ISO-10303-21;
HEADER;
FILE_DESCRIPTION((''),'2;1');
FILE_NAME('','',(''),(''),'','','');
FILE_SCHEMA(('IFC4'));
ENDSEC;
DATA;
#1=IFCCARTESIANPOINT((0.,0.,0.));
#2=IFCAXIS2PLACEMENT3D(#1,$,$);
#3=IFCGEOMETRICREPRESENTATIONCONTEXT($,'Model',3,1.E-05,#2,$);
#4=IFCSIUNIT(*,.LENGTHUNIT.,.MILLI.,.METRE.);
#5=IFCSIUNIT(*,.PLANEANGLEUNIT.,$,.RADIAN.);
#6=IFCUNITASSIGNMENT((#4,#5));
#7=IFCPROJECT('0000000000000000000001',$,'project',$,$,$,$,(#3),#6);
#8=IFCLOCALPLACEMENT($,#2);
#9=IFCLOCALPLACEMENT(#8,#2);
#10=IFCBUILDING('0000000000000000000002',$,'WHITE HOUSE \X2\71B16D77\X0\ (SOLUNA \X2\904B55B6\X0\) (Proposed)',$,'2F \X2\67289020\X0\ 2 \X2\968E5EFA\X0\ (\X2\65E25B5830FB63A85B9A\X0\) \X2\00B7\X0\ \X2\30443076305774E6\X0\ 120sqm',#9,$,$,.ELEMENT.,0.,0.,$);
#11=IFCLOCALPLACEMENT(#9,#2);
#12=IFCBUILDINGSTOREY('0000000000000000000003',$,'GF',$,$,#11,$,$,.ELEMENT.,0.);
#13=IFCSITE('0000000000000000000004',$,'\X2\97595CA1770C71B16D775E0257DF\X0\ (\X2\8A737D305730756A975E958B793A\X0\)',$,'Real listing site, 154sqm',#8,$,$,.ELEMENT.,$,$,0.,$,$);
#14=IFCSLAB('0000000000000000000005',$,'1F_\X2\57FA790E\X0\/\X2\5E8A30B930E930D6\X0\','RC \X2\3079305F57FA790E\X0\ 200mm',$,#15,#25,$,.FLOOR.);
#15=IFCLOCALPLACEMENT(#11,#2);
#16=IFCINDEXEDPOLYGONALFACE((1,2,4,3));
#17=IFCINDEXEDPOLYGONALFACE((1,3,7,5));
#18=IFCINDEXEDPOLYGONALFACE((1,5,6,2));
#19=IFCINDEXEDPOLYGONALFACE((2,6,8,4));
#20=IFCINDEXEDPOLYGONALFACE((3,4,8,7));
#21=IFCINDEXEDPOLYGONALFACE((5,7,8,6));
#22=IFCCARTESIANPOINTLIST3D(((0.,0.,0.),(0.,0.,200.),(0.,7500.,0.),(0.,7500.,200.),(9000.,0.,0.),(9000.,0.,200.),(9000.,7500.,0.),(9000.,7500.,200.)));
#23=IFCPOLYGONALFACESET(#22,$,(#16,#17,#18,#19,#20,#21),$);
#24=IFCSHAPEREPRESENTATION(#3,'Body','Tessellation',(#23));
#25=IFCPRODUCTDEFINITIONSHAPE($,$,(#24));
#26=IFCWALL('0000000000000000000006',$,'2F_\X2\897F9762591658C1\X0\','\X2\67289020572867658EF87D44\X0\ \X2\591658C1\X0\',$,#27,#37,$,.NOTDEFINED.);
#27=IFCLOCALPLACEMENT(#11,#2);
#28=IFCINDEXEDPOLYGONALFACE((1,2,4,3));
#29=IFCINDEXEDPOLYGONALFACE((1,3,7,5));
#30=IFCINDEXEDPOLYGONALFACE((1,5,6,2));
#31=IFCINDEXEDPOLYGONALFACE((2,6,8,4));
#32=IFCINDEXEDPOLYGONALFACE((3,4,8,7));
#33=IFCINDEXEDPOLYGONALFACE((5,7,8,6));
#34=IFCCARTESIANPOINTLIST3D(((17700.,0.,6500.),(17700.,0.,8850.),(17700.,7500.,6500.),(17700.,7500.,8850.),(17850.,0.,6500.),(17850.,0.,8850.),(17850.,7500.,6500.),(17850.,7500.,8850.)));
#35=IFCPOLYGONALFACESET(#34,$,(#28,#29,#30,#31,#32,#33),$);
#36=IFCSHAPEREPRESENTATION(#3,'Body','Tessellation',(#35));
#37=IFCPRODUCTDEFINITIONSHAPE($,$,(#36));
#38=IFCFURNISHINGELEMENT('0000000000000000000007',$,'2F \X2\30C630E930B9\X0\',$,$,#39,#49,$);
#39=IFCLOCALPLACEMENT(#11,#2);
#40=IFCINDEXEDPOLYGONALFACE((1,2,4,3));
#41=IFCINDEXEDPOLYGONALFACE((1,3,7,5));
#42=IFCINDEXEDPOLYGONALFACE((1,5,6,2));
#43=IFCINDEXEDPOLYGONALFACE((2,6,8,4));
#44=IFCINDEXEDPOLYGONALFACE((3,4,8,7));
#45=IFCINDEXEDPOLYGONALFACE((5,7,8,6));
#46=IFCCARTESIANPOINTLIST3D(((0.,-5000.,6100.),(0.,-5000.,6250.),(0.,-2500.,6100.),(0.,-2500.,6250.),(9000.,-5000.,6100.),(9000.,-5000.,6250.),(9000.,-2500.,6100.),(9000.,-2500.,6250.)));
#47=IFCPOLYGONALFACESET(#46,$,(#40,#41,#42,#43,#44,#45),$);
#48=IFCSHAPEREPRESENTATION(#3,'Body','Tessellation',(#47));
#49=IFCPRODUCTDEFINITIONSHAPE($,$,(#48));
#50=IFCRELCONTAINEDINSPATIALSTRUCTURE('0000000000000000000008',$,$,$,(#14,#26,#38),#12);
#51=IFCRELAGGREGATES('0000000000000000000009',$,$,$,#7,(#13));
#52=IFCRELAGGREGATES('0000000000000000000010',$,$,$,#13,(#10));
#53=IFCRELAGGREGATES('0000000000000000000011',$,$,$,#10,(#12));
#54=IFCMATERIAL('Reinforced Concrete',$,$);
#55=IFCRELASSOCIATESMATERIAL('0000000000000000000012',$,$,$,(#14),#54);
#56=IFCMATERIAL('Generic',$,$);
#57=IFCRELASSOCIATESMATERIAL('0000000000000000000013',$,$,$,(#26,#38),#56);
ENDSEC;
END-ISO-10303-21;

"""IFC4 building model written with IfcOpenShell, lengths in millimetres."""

from ifc_helpers import new_model, si_unit, frame, frame_2d, origin, place, context, project, spatial, rectangle, extrude, material, element, save


model = new_model("IFC4")

# Units and contexts
model_context = context("Model", 3, precision=1e-05, world=origin())
ifc_project = project(units=[si_unit("LENGTHUNIT", "METRE", prefix="MILLI"), si_unit("PLANEANGLEUNIT", "RADIAN")], contexts=[model_context])

# Site, building, storey
site_placement = place(None, origin())
site = spatial("IfcSite", under=ifc_project, at=site_placement, Name="静岡県熱海市域 (詳細地番非開示)", ObjectType="Real listing site, 154sqm", CompositionType="ELEMENT", RefElevation=0.0)
building_placement = place(site_placement, origin())
building = spatial("IfcBuilding", under=site, at=building_placement, Name="WHITE HOUSE 熱海 (SOLUNA 運営) (Proposed)", ObjectType="2F 木造 2 階建 (既存・推定) · いぶし瓦 120sqm", CompositionType="ELEMENT", ElevationOfRefHeight=0.0, ElevationOfTerrain=0.0)
storey_placement = place(building_placement, origin())
storey = spatial("IfcBuildingStorey", under=building, at=storey_placement, Name="GF", CompositionType="ELEMENT", Elevation=0.0)

# Slab
ifc_material_1 = material(Name="Reinforced Concrete")
slab_1_placement = place(storey_placement, origin())
element("IfcSlab", 1, at=slab_1_placement, inside=storey, material=ifc_material_1, Name="1F_基礎/床スラブ", Description="RC べた基礎 200mm", PredefinedType="FLOOR", context=model_context, shape_type="SweptSolid", body=[
    extrude(rectangle(XDim=9000.0, YDim=7500.0, at=frame_2d((4500.0, 3750.0))), origin(), (0.0, 0.0, 1.0), 200.0),
])
ifc_material_2 = material(Name="Generic")

# Wall
wall_1_placement = place(storey_placement, frame((8850.0, 0.0, 3250.0)))
element("IfcWall", 2, at=wall_1_placement, inside=storey, material=ifc_material_2, Name="2F_西面外壁", Description="木造在来軸組 外壁", PredefinedType="NOTDEFINED", context=model_context, shape_type="SweptSolid", body=[
    extrude(rectangle(XDim=150.0, YDim=7500.0, at=frame_2d((75.0, 3750.0))), frame((8850.0, 0.0, 3250.0)), (0.0, 0.0, 1.0), 2350.0),
])

# Furnishing element
furnishing_1_placement = place(storey_placement, frame((0.0, -2500.0, 3050.0)))
element("IfcFurnishingElement", 3, at=furnishing_1_placement, inside=storey, material=ifc_material_2, Name="2F テラス", context=model_context, shape_type="SweptSolid", body=[
    extrude(rectangle(XDim=9000.0, YDim=2500.0, at=frame_2d((4500.0, 1250.0))), frame((0.0, -2500.0, 3050.0)), (0.0, 0.0, 1.0), 150.0),
])

save(model, "model.ifc")
